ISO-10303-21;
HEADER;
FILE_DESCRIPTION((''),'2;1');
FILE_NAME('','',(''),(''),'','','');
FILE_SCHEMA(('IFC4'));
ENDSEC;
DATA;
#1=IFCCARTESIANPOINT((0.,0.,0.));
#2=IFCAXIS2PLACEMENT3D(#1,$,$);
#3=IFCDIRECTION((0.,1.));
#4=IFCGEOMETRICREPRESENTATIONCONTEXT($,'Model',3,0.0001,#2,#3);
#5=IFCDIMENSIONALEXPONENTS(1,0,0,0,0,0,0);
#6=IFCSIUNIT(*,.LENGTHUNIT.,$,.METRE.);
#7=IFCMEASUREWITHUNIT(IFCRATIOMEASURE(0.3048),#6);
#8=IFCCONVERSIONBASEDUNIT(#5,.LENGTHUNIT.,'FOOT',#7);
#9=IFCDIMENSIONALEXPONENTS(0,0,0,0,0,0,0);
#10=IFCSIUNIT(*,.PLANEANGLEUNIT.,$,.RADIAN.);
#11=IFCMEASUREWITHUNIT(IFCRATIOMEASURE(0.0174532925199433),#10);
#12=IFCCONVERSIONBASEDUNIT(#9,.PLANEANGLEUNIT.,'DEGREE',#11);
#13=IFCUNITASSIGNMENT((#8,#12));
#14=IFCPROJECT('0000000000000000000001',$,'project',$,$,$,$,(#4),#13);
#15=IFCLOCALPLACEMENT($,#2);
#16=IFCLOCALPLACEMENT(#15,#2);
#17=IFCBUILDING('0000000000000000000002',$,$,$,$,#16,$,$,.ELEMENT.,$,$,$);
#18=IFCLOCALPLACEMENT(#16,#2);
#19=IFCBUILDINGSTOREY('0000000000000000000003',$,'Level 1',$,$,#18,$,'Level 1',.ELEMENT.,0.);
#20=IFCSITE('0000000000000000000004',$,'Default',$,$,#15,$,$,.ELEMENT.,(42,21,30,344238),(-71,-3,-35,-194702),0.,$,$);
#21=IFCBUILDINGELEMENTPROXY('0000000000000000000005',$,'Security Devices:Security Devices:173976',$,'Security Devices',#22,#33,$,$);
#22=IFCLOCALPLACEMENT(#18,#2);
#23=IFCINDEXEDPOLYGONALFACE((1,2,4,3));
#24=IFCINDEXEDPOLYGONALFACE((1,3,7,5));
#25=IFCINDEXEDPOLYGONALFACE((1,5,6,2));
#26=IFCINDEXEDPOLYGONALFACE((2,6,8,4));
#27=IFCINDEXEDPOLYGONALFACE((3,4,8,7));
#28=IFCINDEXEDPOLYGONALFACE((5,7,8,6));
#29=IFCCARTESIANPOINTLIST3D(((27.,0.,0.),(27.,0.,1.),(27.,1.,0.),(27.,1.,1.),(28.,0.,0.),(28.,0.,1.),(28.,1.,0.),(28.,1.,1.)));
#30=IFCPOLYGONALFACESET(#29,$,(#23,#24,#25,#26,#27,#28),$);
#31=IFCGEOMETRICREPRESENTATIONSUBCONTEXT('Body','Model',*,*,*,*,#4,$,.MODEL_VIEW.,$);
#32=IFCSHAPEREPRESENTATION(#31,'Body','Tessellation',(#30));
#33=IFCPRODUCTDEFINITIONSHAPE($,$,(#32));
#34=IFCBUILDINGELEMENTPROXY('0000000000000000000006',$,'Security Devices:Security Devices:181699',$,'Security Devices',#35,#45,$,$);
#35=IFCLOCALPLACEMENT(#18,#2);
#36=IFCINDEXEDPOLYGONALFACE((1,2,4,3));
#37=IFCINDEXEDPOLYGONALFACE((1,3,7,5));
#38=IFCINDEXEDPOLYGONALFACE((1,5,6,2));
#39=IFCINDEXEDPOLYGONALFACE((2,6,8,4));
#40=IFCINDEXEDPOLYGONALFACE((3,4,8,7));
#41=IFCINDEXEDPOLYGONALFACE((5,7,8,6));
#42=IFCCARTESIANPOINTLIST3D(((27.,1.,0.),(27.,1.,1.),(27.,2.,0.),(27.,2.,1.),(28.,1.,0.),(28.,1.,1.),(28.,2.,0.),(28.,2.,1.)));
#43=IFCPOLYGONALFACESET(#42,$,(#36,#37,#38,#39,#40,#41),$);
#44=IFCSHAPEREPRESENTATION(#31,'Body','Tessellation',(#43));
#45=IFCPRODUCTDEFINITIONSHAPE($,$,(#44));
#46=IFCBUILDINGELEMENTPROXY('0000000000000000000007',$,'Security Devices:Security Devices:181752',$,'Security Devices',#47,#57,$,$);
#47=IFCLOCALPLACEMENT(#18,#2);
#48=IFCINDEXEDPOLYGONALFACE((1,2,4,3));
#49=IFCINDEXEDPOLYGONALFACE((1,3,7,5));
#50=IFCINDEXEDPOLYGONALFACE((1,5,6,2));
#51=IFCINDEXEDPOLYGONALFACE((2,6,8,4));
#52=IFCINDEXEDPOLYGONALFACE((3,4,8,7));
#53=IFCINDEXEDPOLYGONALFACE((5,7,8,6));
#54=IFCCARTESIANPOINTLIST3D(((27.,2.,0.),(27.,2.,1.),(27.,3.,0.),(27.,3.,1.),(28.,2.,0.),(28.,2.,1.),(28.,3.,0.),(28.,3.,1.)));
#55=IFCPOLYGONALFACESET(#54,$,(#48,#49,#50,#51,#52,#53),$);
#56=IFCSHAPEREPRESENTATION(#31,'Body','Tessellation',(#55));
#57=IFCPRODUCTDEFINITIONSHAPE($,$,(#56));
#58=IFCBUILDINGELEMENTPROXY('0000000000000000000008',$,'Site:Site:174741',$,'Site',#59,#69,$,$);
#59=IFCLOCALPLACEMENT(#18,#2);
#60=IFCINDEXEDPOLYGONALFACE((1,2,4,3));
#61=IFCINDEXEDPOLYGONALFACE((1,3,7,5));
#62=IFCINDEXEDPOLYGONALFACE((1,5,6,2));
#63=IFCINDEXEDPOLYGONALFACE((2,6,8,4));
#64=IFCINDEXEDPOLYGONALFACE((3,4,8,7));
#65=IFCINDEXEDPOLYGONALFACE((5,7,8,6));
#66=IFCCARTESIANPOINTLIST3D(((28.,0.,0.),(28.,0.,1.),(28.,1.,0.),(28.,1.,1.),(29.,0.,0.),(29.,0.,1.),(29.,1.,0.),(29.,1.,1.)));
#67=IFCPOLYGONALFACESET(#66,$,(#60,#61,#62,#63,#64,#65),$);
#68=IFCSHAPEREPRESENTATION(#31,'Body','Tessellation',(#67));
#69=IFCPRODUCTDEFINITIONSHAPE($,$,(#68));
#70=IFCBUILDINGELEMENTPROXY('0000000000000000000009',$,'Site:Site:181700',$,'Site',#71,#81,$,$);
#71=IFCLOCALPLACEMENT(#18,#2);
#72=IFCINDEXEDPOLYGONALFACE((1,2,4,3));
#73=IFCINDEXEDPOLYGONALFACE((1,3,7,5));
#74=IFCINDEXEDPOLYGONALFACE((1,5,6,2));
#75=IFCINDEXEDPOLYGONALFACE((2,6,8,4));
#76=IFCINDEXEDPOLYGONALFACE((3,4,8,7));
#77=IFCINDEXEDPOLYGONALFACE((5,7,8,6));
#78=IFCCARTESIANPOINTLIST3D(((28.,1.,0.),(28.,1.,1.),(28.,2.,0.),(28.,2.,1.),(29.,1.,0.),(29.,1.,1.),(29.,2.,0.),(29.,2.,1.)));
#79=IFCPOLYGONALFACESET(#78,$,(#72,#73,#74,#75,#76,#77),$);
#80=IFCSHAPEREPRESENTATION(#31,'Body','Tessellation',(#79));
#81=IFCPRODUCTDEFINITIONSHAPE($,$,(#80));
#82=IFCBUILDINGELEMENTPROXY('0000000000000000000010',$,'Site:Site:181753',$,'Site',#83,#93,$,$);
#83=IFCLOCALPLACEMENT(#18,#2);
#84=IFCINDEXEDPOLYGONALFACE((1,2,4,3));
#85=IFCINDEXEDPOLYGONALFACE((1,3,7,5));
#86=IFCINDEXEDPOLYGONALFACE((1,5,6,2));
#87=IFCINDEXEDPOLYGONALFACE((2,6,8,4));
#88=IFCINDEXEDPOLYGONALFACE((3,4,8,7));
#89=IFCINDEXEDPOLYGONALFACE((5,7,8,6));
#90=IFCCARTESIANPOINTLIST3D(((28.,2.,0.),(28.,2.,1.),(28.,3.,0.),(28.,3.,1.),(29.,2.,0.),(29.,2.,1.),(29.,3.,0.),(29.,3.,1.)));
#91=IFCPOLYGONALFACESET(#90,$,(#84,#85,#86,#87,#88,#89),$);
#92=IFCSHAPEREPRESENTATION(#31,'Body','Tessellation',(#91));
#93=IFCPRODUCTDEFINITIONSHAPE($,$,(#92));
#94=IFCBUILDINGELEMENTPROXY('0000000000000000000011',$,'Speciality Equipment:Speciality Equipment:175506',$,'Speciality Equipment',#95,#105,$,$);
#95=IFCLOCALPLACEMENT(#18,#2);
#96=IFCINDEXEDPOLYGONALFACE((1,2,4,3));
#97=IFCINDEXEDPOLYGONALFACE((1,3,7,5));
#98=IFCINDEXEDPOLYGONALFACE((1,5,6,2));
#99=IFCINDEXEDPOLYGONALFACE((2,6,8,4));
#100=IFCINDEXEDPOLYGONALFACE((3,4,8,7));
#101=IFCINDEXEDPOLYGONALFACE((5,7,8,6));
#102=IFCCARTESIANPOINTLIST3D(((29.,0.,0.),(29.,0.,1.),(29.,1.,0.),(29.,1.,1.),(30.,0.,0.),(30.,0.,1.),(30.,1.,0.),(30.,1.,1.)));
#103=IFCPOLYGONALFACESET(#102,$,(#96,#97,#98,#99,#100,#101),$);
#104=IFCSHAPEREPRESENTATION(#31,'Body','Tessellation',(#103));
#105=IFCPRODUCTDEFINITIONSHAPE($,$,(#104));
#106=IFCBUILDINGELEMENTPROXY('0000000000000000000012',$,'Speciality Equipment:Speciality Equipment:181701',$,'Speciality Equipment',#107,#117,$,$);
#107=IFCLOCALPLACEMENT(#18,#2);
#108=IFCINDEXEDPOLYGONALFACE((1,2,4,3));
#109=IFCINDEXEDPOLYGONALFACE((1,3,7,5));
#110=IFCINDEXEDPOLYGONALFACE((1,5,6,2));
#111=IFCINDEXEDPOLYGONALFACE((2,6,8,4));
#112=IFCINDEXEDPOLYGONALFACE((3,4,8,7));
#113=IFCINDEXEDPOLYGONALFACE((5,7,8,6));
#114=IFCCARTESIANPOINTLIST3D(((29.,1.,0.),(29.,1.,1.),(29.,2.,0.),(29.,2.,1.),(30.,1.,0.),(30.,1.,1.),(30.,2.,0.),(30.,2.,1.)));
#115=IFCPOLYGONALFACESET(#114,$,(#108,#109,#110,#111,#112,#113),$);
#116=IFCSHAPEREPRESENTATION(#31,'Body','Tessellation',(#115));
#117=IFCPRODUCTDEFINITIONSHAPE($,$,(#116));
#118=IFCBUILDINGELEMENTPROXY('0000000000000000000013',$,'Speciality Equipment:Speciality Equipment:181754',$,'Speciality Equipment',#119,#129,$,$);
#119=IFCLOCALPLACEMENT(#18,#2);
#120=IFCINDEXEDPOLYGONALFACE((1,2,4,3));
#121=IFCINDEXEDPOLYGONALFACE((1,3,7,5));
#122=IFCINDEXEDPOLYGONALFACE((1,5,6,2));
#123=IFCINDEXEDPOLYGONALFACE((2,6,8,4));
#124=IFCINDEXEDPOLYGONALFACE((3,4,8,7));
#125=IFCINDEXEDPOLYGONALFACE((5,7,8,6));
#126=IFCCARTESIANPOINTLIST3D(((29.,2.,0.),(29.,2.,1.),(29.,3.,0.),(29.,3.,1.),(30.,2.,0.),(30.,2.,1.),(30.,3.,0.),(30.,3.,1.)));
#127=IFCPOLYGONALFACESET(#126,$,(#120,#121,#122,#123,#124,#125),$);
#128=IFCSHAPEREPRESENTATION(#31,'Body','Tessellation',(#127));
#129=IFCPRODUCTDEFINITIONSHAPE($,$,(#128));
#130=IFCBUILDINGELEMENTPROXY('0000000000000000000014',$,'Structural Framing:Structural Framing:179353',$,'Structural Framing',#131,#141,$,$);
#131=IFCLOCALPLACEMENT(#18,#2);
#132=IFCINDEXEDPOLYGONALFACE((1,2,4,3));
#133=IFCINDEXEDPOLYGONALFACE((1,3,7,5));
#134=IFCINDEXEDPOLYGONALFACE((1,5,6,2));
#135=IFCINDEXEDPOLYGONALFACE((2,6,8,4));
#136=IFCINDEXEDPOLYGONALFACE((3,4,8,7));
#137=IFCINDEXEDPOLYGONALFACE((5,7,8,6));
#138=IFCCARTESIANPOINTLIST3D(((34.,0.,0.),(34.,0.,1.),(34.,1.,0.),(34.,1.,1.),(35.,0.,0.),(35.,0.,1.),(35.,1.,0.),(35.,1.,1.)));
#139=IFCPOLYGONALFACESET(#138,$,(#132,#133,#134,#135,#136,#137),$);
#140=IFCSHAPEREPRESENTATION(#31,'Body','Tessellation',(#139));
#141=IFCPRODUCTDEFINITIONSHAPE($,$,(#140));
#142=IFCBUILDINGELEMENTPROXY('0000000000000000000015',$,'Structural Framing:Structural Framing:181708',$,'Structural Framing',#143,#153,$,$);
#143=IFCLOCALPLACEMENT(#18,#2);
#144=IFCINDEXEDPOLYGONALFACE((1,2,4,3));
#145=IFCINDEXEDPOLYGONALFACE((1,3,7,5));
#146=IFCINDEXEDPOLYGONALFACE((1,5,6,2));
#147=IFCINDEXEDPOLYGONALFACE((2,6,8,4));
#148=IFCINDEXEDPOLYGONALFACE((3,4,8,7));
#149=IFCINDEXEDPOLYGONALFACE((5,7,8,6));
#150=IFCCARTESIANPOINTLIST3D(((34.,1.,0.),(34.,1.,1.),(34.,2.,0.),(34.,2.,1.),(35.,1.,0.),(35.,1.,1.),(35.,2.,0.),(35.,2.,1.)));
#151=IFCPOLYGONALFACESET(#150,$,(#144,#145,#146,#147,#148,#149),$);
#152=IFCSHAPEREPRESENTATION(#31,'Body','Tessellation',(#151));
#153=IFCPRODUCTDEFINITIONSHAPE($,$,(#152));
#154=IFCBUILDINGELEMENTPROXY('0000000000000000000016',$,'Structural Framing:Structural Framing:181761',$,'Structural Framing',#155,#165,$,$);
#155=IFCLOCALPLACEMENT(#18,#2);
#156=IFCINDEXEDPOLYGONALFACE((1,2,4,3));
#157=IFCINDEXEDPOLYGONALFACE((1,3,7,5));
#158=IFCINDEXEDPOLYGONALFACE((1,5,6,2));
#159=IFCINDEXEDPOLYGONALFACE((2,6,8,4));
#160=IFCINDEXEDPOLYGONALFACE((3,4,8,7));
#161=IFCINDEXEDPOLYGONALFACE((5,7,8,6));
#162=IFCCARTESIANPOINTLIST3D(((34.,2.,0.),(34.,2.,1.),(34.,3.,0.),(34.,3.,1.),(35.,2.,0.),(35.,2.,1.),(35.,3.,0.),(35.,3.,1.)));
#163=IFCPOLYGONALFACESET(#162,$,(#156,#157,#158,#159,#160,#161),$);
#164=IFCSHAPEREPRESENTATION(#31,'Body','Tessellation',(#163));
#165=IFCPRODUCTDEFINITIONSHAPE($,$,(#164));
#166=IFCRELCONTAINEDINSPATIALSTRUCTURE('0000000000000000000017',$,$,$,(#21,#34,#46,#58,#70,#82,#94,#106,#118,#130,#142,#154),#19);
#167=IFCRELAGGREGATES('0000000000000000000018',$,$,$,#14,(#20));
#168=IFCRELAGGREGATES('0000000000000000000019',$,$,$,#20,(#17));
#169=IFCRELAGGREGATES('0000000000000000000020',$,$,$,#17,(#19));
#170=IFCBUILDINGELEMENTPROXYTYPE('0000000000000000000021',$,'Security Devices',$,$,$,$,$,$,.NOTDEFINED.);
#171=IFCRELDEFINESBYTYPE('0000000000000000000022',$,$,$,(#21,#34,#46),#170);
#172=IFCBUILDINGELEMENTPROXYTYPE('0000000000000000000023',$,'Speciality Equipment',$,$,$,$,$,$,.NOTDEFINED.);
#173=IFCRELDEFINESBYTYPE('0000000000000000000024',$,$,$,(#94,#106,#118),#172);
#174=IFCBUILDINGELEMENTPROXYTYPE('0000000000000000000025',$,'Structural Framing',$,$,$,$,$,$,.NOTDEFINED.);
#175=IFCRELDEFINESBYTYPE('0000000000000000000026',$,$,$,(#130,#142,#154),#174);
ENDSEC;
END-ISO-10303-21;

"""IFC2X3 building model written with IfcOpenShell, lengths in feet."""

from ifc_helpers import new_model, entity, si_unit, converted_unit, direction, frame, frame_2d, origin, place, context, subcontext, project, spatial, rectangle, extrude, source, transform, mapped, type_object, type_shapes, element, save


model = new_model("IFC2X3")

# Units and contexts
model_context = context("Model", 3, precision=0.0001, world=origin(), true_north=direction((0.0, 1.0)))
body_context = subcontext(model_context, "Body", "Model", "MODEL_VIEW")
ifc_project = project(units=[converted_unit("LENGTHUNIT", "FOOT", entity("IfcRatioMeasure", 0.3048), si_unit("LENGTHUNIT", "METRE"), dimensions=[1, 0, 0, 0, 0, 0, 0]), converted_unit("PLANEANGLEUNIT", "DEGREE", entity("IfcRatioMeasure", 0.0174532925199433), si_unit("PLANEANGLEUNIT", "RADIAN"), dimensions=[0, 0, 0, 0, 0, 0, 0])], contexts=[model_context])

# Site, building, storey
site_placement = place(None, origin())
site = spatial("IfcSite", under=ifc_project, at=site_placement, Name="Default", CompositionType="ELEMENT", RefLatitude=(42, 21, 30, 344238), RefLongitude=(-71, -3, -35, -194702), RefElevation=0.0)
building_placement = place(site_placement, origin())
building = spatial("IfcBuilding", under=site, at=building_placement, CompositionType="ELEMENT")
storey_placement = place(building_placement, origin())
storey = spatial("IfcBuildingStorey", under=building, at=storey_placement, Name="Level 1", LongName="Level 1", CompositionType="ELEMENT", Elevation=0.0)

# Building element proxies
building_element_proxy_type_1 = type_object("IfcBuildingElementProxyType", Name="Security Devices", PredefinedType="NOTDEFINED")
shared_shape_1 = source(origin(), body_context, "Body", "SweptSolid", [
    extrude(rectangle(XDim=1.0, YDim=1.0, at=frame_2d((0.0, 0.0), x_axis=(1.0, 0.0))), frame((0.5, 0.5, 0.0), z_axis=(0.0, 0.0, 1.0), x_axis=(0.0, 1.0, 0.0)), (0.0, 0.0, 1.0), 1.0),
])
type_shapes(building_element_proxy_type_1, [shared_shape_1])
for number, where, name in (
    (1, (27.0, 0.0, 0.0), "Security Devices:Security Devices:173976"),
    (2, (27.0, 1.0, 0.0), "Security Devices:Security Devices:181699"),
    (3, (27.0, 2.0, 0.0), "Security Devices:Security Devices:181752"),
):
    element("IfcBuildingElementProxy", number, at=place(storey_placement, frame(where)), inside=storey, type_object=building_element_proxy_type_1, Name=name, ObjectType="Security Devices", context=body_context, shape_type="MappedRepresentation", body=[
        mapped(shared_shape_1, transform((0.0, 0.0, 0.0), scale=1.0)),
    ])
shared_shape_2 = source(origin(), body_context, "Body", "SweptSolid", [
    extrude(rectangle(XDim=1.0, YDim=1.0, at=frame_2d((0.0, 0.0), x_axis=(1.0, 0.0))), frame((0.5, 0.5, 0.0), z_axis=(0.0, 0.0, 1.0), x_axis=(0.0, 1.0, 0.0)), (0.0, 0.0, 1.0), 1.0),
])
for number, where, name in (
    (4, (28.0, 0.0, 0.0), "Site:Site:174741"),
    (5, (28.0, 1.0, 0.0), "Site:Site:181700"),
    (6, (28.0, 2.0, 0.0), "Site:Site:181753"),
):
    element("IfcBuildingElementProxy", number, at=place(storey_placement, frame(where)), inside=storey, Name=name, ObjectType="Site", context=body_context, shape_type="MappedRepresentation", body=[
        mapped(shared_shape_2, transform((0.0, 0.0, 0.0), scale=1.0)),
    ])
building_element_proxy_type_2 = type_object("IfcBuildingElementProxyType", Name="Speciality Equipment", PredefinedType="NOTDEFINED")
shared_shape_3 = source(origin(), body_context, "Body", "SweptSolid", [
    extrude(rectangle(XDim=1.0, YDim=1.0, at=frame_2d((0.0, 0.0), x_axis=(1.0, 0.0))), frame((0.5, 0.5, 0.0), z_axis=(0.0, 0.0, 1.0), x_axis=(0.0, 1.0, 0.0)), (0.0, 0.0, 1.0), 1.0),
])
type_shapes(building_element_proxy_type_2, [shared_shape_3])
for number, where, name in (
    (7, (29.0, 0.0, 0.0), "Speciality Equipment:Speciality Equipment:175506"),
    (8, (29.0, 1.0, 0.0), "Speciality Equipment:Speciality Equipment:181701"),
    (9, (29.0, 2.0, 0.0), "Speciality Equipment:Speciality Equipment:181754"),
):
    element("IfcBuildingElementProxy", number, at=place(storey_placement, frame(where)), inside=storey, type_object=building_element_proxy_type_2, Name=name, ObjectType="Speciality Equipment", context=body_context, shape_type="MappedRepresentation", body=[
        mapped(shared_shape_3, transform((0.0, 0.0, 0.0), scale=1.0)),
    ])
building_element_proxy_type_3 = type_object("IfcBuildingElementProxyType", Name="Structural Framing", PredefinedType="NOTDEFINED")
shared_shape_4 = source(origin(), body_context, "Body", "SweptSolid", [
    extrude(rectangle(XDim=1.0, YDim=1.0, at=frame_2d((0.0, 0.0), x_axis=(1.0, 0.0))), frame((0.5, 0.5, 0.0), z_axis=(0.0, 0.0, 1.0), x_axis=(0.0, 1.0, 0.0)), (0.0, 0.0, 1.0), 1.0),
])
type_shapes(building_element_proxy_type_3, [shared_shape_4])
for number, where, name in (
    (10, (34.0, 0.0, 0.0), "Structural Framing:Structural Framing:179353"),
    (11, (34.0, 1.0, 0.0), "Structural Framing:Structural Framing:181708"),
    (12, (34.0, 2.0, 0.0), "Structural Framing:Structural Framing:181761"),
):
    element("IfcBuildingElementProxy", number, at=place(storey_placement, frame(where)), inside=storey, type_object=building_element_proxy_type_3, Name=name, ObjectType="Structural Framing", context=body_context, shape_type="MappedRepresentation", body=[
        mapped(shared_shape_4, transform((0.0, 0.0, 0.0), scale=1.0)),
    ])

save(model, "model.ifc")
